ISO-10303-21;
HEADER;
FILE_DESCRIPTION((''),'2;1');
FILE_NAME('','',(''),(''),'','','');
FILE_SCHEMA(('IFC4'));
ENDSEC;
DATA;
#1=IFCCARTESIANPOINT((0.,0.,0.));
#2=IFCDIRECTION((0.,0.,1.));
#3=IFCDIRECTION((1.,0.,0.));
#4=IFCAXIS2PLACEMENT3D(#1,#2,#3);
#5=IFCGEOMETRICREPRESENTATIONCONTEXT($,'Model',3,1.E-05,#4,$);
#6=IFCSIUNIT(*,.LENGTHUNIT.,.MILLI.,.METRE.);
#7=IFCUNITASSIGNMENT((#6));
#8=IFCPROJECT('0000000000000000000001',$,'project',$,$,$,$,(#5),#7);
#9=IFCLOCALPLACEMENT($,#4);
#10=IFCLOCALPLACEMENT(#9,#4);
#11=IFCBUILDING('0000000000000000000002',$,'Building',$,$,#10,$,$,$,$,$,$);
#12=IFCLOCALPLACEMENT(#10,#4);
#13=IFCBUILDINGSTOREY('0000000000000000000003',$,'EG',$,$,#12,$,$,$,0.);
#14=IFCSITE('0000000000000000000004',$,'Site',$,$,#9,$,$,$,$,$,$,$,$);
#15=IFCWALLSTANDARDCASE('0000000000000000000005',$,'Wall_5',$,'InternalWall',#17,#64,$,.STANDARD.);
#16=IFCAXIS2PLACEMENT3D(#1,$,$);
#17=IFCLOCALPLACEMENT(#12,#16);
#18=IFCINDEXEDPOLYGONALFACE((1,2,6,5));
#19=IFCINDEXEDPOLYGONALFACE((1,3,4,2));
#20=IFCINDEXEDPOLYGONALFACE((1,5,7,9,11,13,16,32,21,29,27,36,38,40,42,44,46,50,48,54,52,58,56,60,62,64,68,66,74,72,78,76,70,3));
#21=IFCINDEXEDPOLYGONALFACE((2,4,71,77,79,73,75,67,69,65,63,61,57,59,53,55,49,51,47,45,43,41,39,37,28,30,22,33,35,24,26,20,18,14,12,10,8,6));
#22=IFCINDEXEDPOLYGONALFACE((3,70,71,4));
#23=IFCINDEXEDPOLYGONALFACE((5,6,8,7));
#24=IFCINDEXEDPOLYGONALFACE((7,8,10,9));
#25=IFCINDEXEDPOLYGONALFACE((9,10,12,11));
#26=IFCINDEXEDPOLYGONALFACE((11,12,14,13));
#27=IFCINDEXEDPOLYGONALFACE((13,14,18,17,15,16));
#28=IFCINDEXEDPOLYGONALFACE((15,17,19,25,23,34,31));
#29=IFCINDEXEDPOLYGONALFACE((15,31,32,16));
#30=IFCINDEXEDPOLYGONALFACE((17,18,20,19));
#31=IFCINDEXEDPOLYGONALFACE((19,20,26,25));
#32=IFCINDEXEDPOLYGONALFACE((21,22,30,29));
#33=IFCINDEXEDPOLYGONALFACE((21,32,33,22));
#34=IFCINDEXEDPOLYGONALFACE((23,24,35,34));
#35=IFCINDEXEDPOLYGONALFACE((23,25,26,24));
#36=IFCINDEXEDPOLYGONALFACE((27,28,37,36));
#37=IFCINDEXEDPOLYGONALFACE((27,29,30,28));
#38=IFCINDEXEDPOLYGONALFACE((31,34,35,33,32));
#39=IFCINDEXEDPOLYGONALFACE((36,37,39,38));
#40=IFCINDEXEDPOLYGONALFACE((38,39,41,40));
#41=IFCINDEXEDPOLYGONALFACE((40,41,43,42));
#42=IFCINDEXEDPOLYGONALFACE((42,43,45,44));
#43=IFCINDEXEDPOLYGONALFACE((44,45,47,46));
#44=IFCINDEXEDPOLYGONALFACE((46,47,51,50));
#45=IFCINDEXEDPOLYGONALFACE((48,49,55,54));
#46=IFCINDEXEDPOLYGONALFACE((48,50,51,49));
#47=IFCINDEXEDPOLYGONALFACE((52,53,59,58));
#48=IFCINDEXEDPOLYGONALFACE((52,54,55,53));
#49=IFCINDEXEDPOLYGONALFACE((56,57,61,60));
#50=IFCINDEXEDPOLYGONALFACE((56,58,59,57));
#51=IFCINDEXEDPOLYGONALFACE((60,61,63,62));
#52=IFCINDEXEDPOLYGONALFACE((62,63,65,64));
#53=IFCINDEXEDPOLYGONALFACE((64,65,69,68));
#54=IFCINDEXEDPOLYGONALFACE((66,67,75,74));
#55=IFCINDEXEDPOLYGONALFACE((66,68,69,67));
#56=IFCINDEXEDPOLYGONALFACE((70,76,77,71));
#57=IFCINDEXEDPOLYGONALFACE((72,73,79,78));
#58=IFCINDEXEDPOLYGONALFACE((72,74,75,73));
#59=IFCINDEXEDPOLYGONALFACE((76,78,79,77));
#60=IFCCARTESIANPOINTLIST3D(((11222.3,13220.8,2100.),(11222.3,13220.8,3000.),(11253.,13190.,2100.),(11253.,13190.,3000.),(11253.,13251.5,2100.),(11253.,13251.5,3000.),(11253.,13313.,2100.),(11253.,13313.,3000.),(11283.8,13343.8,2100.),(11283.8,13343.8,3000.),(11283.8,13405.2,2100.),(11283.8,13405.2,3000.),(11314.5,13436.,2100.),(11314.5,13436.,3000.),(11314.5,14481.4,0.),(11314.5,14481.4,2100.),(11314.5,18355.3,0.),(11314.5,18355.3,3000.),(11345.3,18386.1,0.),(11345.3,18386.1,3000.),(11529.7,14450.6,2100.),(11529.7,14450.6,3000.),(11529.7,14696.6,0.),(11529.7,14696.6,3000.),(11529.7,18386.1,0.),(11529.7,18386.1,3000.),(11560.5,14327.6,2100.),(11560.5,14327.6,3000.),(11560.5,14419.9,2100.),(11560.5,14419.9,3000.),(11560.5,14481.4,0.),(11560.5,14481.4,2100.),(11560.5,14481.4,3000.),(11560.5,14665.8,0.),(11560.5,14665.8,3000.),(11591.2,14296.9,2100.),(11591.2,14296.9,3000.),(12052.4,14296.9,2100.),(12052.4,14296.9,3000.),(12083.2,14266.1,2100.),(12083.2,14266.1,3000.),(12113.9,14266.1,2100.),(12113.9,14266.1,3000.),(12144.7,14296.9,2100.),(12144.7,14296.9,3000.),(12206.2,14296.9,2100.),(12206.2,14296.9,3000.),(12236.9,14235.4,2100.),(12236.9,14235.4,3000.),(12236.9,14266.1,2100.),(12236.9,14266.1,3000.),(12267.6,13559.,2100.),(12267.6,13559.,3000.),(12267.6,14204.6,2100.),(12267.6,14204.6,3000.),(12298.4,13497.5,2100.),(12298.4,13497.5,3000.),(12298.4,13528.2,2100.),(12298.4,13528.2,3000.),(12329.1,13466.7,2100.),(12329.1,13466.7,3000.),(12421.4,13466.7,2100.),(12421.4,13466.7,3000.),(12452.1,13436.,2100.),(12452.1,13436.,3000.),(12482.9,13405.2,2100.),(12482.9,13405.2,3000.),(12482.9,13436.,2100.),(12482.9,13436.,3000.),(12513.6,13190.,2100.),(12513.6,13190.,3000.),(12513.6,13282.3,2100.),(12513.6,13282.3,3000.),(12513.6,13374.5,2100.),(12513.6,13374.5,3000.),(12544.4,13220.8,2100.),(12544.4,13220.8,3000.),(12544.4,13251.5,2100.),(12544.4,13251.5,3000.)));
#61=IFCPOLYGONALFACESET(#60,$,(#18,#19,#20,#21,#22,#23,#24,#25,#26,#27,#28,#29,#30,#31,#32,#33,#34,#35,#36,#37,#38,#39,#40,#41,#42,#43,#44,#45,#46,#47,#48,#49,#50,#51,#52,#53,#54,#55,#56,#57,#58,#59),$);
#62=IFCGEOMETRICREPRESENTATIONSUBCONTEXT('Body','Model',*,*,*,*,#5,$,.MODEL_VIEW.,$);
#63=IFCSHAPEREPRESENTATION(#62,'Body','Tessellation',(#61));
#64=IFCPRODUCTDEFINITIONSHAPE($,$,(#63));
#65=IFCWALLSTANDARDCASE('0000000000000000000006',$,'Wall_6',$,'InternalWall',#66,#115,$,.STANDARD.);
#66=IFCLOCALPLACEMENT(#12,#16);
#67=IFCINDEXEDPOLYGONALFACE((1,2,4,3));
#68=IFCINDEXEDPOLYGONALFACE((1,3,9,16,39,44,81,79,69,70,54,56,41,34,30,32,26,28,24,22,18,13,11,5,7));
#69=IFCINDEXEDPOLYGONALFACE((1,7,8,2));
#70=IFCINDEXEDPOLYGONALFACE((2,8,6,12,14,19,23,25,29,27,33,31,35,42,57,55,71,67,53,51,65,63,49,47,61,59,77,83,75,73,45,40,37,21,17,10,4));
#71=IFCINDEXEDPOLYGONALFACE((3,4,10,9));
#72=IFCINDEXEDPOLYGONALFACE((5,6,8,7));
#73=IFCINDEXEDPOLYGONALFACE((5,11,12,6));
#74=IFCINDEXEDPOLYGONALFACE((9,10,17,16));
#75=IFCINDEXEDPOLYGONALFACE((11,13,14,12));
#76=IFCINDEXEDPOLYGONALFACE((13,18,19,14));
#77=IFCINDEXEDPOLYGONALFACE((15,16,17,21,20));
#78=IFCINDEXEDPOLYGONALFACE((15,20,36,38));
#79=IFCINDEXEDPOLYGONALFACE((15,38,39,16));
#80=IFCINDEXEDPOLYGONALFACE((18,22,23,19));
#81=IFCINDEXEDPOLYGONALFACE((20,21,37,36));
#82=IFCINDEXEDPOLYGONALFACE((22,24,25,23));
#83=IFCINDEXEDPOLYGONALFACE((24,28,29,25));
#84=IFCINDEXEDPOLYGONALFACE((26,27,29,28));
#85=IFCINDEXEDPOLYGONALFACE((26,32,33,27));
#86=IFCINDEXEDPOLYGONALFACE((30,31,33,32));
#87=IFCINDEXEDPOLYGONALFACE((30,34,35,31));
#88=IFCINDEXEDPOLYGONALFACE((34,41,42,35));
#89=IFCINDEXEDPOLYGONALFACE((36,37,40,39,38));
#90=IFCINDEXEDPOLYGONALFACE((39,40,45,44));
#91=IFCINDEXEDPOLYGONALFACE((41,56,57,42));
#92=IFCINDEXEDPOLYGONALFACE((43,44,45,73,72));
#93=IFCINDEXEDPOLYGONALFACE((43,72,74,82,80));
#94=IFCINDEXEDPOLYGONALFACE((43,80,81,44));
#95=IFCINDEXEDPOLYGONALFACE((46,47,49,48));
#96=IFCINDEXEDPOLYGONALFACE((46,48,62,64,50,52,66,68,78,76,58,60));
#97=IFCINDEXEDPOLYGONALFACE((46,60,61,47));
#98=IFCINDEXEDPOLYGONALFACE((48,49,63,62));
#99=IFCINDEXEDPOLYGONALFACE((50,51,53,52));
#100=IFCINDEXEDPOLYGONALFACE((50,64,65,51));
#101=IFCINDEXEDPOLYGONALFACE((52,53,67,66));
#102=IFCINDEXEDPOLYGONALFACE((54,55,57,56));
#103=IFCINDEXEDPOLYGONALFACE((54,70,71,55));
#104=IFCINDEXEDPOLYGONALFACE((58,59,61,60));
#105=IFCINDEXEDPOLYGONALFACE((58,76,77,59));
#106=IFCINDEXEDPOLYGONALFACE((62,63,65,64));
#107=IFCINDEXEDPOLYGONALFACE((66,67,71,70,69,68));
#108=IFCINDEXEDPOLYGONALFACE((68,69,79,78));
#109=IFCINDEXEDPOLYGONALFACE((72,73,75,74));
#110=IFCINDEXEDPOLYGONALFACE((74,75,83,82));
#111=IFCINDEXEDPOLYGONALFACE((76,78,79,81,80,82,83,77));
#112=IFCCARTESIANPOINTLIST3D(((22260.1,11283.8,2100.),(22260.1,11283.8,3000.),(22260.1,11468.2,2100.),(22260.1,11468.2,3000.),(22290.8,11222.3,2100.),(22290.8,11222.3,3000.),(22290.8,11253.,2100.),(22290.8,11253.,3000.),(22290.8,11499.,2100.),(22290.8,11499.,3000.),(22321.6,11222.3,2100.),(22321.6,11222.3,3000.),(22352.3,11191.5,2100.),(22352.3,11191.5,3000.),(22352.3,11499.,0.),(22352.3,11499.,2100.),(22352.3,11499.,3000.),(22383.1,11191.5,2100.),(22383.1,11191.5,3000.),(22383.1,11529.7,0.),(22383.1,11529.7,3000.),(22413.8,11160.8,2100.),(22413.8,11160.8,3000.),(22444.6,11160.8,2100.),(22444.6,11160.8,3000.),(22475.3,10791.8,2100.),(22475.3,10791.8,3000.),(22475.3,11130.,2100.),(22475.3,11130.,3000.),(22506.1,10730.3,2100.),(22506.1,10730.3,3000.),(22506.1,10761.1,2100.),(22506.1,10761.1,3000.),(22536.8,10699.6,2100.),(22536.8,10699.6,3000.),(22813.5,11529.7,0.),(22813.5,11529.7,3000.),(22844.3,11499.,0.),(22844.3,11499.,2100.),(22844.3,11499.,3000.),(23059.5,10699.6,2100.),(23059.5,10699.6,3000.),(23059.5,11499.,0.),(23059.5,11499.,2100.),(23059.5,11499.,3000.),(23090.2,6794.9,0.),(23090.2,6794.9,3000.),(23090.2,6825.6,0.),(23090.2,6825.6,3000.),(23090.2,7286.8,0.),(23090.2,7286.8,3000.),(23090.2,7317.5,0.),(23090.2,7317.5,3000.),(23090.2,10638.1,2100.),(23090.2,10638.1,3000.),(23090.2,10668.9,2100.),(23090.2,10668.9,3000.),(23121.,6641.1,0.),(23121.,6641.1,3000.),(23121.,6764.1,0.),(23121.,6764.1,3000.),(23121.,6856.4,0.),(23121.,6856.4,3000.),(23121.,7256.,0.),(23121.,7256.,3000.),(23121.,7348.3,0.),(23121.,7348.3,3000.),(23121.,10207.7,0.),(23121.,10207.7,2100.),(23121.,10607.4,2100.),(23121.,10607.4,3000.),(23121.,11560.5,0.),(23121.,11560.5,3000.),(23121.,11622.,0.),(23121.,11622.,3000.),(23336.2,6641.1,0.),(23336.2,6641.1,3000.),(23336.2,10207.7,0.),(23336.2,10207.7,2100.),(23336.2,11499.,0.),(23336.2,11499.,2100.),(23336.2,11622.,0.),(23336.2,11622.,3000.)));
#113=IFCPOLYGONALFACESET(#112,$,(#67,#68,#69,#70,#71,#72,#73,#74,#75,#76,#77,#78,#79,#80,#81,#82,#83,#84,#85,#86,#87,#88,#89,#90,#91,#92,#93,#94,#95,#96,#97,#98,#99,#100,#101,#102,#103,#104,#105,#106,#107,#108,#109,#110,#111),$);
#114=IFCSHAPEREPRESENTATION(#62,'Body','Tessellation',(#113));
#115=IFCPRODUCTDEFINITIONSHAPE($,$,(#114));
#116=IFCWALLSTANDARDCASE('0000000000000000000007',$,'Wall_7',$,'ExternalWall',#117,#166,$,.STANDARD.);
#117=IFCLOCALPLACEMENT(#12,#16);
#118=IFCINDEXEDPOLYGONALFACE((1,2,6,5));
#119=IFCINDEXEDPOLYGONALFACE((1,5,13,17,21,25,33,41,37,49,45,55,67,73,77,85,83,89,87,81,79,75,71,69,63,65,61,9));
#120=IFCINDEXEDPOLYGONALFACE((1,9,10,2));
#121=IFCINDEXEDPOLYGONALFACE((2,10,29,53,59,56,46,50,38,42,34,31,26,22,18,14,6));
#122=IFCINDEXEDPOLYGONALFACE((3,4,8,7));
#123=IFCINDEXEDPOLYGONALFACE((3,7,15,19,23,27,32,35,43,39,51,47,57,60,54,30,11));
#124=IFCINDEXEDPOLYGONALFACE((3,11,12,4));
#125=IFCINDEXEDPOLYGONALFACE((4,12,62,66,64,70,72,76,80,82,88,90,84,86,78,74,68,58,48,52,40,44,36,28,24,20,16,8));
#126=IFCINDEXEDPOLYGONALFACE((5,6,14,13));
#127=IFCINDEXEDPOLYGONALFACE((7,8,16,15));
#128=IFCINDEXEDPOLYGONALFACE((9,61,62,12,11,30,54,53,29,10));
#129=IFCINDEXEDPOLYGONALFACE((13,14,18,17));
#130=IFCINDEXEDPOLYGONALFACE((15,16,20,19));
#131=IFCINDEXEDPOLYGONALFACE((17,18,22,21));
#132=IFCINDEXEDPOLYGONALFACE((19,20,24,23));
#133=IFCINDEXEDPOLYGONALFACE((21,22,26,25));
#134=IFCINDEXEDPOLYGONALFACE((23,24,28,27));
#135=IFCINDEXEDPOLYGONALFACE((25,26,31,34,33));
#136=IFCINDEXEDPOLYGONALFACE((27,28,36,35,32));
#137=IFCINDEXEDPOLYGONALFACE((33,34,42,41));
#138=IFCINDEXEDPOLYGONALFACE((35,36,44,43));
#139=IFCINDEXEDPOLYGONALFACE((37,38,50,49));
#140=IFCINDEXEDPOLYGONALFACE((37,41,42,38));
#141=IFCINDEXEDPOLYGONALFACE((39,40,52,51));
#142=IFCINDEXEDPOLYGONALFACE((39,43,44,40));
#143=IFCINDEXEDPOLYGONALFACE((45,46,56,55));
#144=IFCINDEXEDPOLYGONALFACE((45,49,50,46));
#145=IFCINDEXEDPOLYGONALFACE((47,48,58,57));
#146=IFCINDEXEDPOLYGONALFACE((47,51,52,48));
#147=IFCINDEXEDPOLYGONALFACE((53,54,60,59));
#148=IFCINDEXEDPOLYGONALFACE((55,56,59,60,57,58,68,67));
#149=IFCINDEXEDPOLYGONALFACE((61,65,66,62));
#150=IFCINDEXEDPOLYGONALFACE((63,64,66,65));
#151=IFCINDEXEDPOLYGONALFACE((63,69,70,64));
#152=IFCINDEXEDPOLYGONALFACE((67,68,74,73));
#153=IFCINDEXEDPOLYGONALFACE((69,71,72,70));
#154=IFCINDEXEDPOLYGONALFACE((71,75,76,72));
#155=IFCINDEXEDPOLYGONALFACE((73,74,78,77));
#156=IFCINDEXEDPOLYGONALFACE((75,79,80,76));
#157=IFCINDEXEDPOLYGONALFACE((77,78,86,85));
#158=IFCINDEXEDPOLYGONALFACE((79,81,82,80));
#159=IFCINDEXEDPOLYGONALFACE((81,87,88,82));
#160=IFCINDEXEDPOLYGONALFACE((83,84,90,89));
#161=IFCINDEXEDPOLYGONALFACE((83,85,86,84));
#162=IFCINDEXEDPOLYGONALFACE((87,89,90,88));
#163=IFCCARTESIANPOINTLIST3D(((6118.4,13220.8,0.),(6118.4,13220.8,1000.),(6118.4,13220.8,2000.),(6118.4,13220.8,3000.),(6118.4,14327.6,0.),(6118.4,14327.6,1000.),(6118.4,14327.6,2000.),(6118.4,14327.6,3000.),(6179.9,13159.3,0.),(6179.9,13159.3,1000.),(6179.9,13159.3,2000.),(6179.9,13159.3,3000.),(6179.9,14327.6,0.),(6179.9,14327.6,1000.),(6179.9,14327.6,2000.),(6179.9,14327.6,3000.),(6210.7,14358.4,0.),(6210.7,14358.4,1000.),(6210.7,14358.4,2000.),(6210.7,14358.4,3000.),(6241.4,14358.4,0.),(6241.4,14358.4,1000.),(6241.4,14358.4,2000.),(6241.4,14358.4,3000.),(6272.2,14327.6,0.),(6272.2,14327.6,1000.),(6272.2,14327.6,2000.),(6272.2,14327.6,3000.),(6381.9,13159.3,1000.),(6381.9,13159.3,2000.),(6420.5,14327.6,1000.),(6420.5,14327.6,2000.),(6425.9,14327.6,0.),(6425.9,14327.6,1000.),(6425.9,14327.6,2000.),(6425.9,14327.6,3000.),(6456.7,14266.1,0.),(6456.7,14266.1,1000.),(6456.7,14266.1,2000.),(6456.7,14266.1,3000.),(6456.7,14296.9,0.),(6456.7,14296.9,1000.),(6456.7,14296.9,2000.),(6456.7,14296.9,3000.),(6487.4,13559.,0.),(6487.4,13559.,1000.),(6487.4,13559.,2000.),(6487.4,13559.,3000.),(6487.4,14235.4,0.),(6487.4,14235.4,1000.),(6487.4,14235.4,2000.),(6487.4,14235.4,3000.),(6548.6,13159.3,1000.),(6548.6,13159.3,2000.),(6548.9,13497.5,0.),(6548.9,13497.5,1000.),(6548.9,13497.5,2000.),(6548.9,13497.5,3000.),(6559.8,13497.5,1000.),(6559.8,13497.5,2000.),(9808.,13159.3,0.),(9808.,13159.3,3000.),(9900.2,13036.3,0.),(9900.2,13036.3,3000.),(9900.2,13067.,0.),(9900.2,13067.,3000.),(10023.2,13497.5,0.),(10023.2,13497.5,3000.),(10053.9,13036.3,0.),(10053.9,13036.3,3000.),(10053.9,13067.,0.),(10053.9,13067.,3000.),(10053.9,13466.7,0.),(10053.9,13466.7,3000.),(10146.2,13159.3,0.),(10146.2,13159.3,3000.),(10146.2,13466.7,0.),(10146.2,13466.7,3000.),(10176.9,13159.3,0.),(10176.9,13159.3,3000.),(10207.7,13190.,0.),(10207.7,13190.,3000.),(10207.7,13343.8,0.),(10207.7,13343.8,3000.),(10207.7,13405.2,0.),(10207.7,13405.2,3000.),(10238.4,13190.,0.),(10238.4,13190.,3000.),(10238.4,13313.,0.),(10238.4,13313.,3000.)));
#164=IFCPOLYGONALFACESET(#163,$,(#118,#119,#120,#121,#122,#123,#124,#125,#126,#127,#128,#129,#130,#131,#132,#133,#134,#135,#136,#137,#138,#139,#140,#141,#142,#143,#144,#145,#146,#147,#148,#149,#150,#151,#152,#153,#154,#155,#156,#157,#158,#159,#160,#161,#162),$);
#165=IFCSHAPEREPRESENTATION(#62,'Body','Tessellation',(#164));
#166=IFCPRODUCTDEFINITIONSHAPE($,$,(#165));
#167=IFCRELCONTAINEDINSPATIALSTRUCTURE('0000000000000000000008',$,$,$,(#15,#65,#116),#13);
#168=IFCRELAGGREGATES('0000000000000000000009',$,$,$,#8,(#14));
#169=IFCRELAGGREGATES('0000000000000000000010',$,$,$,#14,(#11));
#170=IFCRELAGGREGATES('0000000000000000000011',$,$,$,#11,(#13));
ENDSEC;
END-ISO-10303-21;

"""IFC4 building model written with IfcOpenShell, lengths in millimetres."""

from ifc_helpers import new_model, si_unit, frame, origin_with_axes, place, context, subcontext, project, spatial, polyline, rectangle, outline, extrude, element, save


model = new_model("IFC4")

# Units and contexts
model_context = context("Model", 3, precision=1e-05, world=origin_with_axes())
body_context = subcontext(model_context, "Body", "Model", "MODEL_VIEW")
ifc_project = project(units=[si_unit("LENGTHUNIT", "METRE", prefix="MILLI")], contexts=[model_context])

# Site, building, storey
site_placement = place(None, origin_with_axes())
site = spatial("IfcSite", under=ifc_project, at=site_placement, Name="Site")
building_placement = place(site_placement, origin_with_axes())
building = spatial("IfcBuilding", under=site, at=building_placement, Name="Building")
storey_placement = place(building_placement, origin_with_axes())
storey = spatial("IfcBuildingStorey", under=building, at=storey_placement, Name="EG", Elevation=0.0)

# Walls, openings
wall_1_placement = place(storey_placement, origin_with_axes())
wall_1 = element("IfcWallStandardCase", 1, at=wall_1_placement, inside=storey, Name="Wall_5", ObjectType="InternalWall", PredefinedType="STANDARD", context=body_context, shape_type="SweptSolid", body=[
    extrude(outline(polyline([(11253.0, 13190.0, 0.0), (11222.3, 13220.8, 0.0), (11253.0, 13251.5, 0.0), (11253.0, 13313.0, 0.0), (11283.8, 13343.8, 0.0), (11283.8, 13405.2, 0.0), (11314.5, 13436.0, 0.0), (11314.5, 18355.3, 0.0), (11345.3, 18386.1, 0.0), (11529.7, 18386.1, 0.0), (11529.7, 14696.6, 0.0), (11560.5, 14665.8, 0.0), (11560.5, 14481.4, 0.0), (11529.7, 14450.6, 0.0), (11560.5, 14419.9, 0.0), (11560.5, 14327.6, 0.0), (11591.2, 14296.9, 0.0), (12052.4, 14296.9, 0.0), (12083.2, 14266.1, 0.0), (12113.9, 14266.1, 0.0), (12144.7, 14296.9, 0.0), (12206.2, 14296.9, 0.0), (12236.9, 14266.1, 0.0), (12236.9, 14235.4, 0.0), (12267.6, 14204.6, 0.0), (12267.6, 13559.0, 0.0), (12298.4, 13528.2, 0.0), (12298.4, 13497.5, 0.0), (12329.1, 13466.7, 0.0), (12421.4, 13466.7, 0.0), (12452.1, 13436.0, 0.0), (12482.9, 13436.0, 0.0), (12482.9, 13405.2, 0.0), (12513.6, 13374.5, 0.0), (12513.6, 13282.3, 0.0), (12544.4, 13251.5, 0.0), (12544.4, 13220.8, 0.0), (12513.6, 13190.0, 0.0), (11253.0, 13190.0, 0.0)])), origin_with_axes(), (0.0, 0.0, 1.0), 3000.0),
])
opening_1_placement = place(wall_1_placement, origin_with_axes())
element("IfcOpeningElement", 2, at=opening_1_placement, inside=storey, cuts=wall_1, context=body_context, shape_type="SweptSolid", body=[
    extrude(rectangle(XDim=1291.3, YDim=1322.1), frame((11883.3, 13835.7, 0.0), z_axis=(0.0, 0.0, 1.0), x_axis=(0.0, -1.0, 0.0)), (0.0, 0.0, 1.0), 2100.0),
])
wall_2_placement = place(storey_placement, origin_with_axes())
wall_2 = element("IfcWallStandardCase", 3, at=wall_2_placement, inside=storey, Name="Wall_6", ObjectType="InternalWall", PredefinedType="STANDARD", context=body_context, shape_type="SweptSolid", body=[
    extrude(outline(polyline([(23121.0, 6641.1, 0.0), (23121.0, 6764.1, 0.0), (23090.2, 6794.9, 0.0), (23090.2, 6825.6, 0.0), (23121.0, 6856.4, 0.0), (23121.0, 7256.0, 0.0), (23090.2, 7286.8, 0.0), (23090.2, 7317.5, 0.0), (23121.0, 7348.3, 0.0), (23121.0, 10607.4, 0.0), (23090.2, 10638.1, 0.0), (23090.2, 10668.9, 0.0), (23059.5, 10699.6, 0.0), (22536.8, 10699.6, 0.0), (22506.1, 10730.3, 0.0), (22506.1, 10761.1, 0.0), (22475.3, 10791.8, 0.0), (22475.3, 11130.0, 0.0), (22444.6, 11160.8, 0.0), (22413.8, 11160.8, 0.0), (22383.1, 11191.5, 0.0), (22352.3, 11191.5, 0.0), (22321.6, 11222.3, 0.0), (22290.8, 11222.3, 0.0), (22290.8, 11253.0, 0.0), (22260.1, 11283.8, 0.0), (22260.1, 11468.2, 0.0), (22290.8, 11499.0, 0.0), (22352.3, 11499.0, 0.0), (22383.1, 11529.7, 0.0), (22813.5, 11529.7, 0.0), (22844.3, 11499.0, 0.0), (23059.5, 11499.0, 0.0), (23121.0, 11560.5, 0.0), (23121.0, 11622.0, 0.0), (23336.2, 11622.0, 0.0), (23336.2, 6641.1, 0.0), (23121.0, 6641.1, 0.0)])), origin_with_axes(), (0.0, 0.0, 1.0), 3000.0),
])
opening_2_placement = place(wall_2_placement, origin_with_axes())
element("IfcOpeningElement", 4, at=opening_2_placement, inside=storey, cuts=wall_2, context=body_context, shape_type="SweptSolid", body=[
    extrude(rectangle(XDim=1291.3, YDim=1076.1), frame((22798.1, 10853.3, 0.0), z_axis=(0.0, 0.0, 1.0), x_axis=(0.0, 1.0, 0.0)), (0.0, 0.0, 1.0), 2100.0),
])

# Wall, openings
wall_3_placement = place(storey_placement, origin_with_axes())
wall_3 = element("IfcWallStandardCase", 5, at=wall_3_placement, inside=storey, Name="Wall_7", ObjectType="ExternalWall", PredefinedType="STANDARD", context=body_context, shape_type="SweptSolid", body=[
    extrude(outline(polyline([(9900.2, 13036.3, 0.0), (9900.2, 13067.0, 0.0), (9808.0, 13159.3, 0.0), (6179.9, 13159.3, 0.0), (6118.4, 13220.8, 0.0), (6118.4, 14327.6, 0.0), (6179.9, 14327.6, 0.0), (6210.7, 14358.4, 0.0), (6241.4, 14358.4, 0.0), (6272.2, 14327.6, 0.0), (6425.9, 14327.6, 0.0), (6456.7, 14296.9, 0.0), (6456.7, 14266.1, 0.0), (6487.4, 14235.4, 0.0), (6487.4, 13559.0, 0.0), (6548.9, 13497.5, 0.0), (10023.2, 13497.5, 0.0), (10053.9, 13466.7, 0.0), (10146.2, 13466.7, 0.0), (10207.7, 13405.2, 0.0), (10207.7, 13343.8, 0.0), (10238.4, 13313.0, 0.0), (10238.4, 13190.0, 0.0), (10207.7, 13190.0, 0.0), (10176.9, 13159.3, 0.0), (10146.2, 13159.3, 0.0), (10053.9, 13067.0, 0.0), (10053.9, 13036.3, 0.0), (9900.2, 13036.3, 0.0)])), origin_with_axes(), (0.0, 0.0, 1.0), 3000.0),
])
opening_3_placement = place(wall_3_placement, origin_with_axes())
element("IfcOpeningElement", 6, at=opening_3_placement, inside=storey, cuts=wall_3, context=body_context, shape_type="SweptSolid", body=[
    extrude(rectangle(XDim=600.0, YDim=1200.5), frame((6268.2, 13756.9, 1000.0), z_axis=(0.0, 0.0, 1.0), x_axis=(-0.999454, 0.03304, 0.0)), (0.0, 0.0, 1.0), 1000.0),
])
opening_4_placement = place(wall_3_placement, origin_with_axes())
element("IfcOpeningElement", 7, at=opening_4_placement, inside=storey, cuts=wall_3, context=body_context, shape_type="SweptSolid", body=[
    extrude(rectangle(XDim=600.0, YDim=1200.5), frame((6101.7, 13762.4, 1000.0), z_axis=(0.0, 0.0, 1.0), x_axis=(-0.999454, 0.03304, 0.0)), (0.0, 0.0, 1.0), 1000.0),
])

save(model, "model.ifc")
